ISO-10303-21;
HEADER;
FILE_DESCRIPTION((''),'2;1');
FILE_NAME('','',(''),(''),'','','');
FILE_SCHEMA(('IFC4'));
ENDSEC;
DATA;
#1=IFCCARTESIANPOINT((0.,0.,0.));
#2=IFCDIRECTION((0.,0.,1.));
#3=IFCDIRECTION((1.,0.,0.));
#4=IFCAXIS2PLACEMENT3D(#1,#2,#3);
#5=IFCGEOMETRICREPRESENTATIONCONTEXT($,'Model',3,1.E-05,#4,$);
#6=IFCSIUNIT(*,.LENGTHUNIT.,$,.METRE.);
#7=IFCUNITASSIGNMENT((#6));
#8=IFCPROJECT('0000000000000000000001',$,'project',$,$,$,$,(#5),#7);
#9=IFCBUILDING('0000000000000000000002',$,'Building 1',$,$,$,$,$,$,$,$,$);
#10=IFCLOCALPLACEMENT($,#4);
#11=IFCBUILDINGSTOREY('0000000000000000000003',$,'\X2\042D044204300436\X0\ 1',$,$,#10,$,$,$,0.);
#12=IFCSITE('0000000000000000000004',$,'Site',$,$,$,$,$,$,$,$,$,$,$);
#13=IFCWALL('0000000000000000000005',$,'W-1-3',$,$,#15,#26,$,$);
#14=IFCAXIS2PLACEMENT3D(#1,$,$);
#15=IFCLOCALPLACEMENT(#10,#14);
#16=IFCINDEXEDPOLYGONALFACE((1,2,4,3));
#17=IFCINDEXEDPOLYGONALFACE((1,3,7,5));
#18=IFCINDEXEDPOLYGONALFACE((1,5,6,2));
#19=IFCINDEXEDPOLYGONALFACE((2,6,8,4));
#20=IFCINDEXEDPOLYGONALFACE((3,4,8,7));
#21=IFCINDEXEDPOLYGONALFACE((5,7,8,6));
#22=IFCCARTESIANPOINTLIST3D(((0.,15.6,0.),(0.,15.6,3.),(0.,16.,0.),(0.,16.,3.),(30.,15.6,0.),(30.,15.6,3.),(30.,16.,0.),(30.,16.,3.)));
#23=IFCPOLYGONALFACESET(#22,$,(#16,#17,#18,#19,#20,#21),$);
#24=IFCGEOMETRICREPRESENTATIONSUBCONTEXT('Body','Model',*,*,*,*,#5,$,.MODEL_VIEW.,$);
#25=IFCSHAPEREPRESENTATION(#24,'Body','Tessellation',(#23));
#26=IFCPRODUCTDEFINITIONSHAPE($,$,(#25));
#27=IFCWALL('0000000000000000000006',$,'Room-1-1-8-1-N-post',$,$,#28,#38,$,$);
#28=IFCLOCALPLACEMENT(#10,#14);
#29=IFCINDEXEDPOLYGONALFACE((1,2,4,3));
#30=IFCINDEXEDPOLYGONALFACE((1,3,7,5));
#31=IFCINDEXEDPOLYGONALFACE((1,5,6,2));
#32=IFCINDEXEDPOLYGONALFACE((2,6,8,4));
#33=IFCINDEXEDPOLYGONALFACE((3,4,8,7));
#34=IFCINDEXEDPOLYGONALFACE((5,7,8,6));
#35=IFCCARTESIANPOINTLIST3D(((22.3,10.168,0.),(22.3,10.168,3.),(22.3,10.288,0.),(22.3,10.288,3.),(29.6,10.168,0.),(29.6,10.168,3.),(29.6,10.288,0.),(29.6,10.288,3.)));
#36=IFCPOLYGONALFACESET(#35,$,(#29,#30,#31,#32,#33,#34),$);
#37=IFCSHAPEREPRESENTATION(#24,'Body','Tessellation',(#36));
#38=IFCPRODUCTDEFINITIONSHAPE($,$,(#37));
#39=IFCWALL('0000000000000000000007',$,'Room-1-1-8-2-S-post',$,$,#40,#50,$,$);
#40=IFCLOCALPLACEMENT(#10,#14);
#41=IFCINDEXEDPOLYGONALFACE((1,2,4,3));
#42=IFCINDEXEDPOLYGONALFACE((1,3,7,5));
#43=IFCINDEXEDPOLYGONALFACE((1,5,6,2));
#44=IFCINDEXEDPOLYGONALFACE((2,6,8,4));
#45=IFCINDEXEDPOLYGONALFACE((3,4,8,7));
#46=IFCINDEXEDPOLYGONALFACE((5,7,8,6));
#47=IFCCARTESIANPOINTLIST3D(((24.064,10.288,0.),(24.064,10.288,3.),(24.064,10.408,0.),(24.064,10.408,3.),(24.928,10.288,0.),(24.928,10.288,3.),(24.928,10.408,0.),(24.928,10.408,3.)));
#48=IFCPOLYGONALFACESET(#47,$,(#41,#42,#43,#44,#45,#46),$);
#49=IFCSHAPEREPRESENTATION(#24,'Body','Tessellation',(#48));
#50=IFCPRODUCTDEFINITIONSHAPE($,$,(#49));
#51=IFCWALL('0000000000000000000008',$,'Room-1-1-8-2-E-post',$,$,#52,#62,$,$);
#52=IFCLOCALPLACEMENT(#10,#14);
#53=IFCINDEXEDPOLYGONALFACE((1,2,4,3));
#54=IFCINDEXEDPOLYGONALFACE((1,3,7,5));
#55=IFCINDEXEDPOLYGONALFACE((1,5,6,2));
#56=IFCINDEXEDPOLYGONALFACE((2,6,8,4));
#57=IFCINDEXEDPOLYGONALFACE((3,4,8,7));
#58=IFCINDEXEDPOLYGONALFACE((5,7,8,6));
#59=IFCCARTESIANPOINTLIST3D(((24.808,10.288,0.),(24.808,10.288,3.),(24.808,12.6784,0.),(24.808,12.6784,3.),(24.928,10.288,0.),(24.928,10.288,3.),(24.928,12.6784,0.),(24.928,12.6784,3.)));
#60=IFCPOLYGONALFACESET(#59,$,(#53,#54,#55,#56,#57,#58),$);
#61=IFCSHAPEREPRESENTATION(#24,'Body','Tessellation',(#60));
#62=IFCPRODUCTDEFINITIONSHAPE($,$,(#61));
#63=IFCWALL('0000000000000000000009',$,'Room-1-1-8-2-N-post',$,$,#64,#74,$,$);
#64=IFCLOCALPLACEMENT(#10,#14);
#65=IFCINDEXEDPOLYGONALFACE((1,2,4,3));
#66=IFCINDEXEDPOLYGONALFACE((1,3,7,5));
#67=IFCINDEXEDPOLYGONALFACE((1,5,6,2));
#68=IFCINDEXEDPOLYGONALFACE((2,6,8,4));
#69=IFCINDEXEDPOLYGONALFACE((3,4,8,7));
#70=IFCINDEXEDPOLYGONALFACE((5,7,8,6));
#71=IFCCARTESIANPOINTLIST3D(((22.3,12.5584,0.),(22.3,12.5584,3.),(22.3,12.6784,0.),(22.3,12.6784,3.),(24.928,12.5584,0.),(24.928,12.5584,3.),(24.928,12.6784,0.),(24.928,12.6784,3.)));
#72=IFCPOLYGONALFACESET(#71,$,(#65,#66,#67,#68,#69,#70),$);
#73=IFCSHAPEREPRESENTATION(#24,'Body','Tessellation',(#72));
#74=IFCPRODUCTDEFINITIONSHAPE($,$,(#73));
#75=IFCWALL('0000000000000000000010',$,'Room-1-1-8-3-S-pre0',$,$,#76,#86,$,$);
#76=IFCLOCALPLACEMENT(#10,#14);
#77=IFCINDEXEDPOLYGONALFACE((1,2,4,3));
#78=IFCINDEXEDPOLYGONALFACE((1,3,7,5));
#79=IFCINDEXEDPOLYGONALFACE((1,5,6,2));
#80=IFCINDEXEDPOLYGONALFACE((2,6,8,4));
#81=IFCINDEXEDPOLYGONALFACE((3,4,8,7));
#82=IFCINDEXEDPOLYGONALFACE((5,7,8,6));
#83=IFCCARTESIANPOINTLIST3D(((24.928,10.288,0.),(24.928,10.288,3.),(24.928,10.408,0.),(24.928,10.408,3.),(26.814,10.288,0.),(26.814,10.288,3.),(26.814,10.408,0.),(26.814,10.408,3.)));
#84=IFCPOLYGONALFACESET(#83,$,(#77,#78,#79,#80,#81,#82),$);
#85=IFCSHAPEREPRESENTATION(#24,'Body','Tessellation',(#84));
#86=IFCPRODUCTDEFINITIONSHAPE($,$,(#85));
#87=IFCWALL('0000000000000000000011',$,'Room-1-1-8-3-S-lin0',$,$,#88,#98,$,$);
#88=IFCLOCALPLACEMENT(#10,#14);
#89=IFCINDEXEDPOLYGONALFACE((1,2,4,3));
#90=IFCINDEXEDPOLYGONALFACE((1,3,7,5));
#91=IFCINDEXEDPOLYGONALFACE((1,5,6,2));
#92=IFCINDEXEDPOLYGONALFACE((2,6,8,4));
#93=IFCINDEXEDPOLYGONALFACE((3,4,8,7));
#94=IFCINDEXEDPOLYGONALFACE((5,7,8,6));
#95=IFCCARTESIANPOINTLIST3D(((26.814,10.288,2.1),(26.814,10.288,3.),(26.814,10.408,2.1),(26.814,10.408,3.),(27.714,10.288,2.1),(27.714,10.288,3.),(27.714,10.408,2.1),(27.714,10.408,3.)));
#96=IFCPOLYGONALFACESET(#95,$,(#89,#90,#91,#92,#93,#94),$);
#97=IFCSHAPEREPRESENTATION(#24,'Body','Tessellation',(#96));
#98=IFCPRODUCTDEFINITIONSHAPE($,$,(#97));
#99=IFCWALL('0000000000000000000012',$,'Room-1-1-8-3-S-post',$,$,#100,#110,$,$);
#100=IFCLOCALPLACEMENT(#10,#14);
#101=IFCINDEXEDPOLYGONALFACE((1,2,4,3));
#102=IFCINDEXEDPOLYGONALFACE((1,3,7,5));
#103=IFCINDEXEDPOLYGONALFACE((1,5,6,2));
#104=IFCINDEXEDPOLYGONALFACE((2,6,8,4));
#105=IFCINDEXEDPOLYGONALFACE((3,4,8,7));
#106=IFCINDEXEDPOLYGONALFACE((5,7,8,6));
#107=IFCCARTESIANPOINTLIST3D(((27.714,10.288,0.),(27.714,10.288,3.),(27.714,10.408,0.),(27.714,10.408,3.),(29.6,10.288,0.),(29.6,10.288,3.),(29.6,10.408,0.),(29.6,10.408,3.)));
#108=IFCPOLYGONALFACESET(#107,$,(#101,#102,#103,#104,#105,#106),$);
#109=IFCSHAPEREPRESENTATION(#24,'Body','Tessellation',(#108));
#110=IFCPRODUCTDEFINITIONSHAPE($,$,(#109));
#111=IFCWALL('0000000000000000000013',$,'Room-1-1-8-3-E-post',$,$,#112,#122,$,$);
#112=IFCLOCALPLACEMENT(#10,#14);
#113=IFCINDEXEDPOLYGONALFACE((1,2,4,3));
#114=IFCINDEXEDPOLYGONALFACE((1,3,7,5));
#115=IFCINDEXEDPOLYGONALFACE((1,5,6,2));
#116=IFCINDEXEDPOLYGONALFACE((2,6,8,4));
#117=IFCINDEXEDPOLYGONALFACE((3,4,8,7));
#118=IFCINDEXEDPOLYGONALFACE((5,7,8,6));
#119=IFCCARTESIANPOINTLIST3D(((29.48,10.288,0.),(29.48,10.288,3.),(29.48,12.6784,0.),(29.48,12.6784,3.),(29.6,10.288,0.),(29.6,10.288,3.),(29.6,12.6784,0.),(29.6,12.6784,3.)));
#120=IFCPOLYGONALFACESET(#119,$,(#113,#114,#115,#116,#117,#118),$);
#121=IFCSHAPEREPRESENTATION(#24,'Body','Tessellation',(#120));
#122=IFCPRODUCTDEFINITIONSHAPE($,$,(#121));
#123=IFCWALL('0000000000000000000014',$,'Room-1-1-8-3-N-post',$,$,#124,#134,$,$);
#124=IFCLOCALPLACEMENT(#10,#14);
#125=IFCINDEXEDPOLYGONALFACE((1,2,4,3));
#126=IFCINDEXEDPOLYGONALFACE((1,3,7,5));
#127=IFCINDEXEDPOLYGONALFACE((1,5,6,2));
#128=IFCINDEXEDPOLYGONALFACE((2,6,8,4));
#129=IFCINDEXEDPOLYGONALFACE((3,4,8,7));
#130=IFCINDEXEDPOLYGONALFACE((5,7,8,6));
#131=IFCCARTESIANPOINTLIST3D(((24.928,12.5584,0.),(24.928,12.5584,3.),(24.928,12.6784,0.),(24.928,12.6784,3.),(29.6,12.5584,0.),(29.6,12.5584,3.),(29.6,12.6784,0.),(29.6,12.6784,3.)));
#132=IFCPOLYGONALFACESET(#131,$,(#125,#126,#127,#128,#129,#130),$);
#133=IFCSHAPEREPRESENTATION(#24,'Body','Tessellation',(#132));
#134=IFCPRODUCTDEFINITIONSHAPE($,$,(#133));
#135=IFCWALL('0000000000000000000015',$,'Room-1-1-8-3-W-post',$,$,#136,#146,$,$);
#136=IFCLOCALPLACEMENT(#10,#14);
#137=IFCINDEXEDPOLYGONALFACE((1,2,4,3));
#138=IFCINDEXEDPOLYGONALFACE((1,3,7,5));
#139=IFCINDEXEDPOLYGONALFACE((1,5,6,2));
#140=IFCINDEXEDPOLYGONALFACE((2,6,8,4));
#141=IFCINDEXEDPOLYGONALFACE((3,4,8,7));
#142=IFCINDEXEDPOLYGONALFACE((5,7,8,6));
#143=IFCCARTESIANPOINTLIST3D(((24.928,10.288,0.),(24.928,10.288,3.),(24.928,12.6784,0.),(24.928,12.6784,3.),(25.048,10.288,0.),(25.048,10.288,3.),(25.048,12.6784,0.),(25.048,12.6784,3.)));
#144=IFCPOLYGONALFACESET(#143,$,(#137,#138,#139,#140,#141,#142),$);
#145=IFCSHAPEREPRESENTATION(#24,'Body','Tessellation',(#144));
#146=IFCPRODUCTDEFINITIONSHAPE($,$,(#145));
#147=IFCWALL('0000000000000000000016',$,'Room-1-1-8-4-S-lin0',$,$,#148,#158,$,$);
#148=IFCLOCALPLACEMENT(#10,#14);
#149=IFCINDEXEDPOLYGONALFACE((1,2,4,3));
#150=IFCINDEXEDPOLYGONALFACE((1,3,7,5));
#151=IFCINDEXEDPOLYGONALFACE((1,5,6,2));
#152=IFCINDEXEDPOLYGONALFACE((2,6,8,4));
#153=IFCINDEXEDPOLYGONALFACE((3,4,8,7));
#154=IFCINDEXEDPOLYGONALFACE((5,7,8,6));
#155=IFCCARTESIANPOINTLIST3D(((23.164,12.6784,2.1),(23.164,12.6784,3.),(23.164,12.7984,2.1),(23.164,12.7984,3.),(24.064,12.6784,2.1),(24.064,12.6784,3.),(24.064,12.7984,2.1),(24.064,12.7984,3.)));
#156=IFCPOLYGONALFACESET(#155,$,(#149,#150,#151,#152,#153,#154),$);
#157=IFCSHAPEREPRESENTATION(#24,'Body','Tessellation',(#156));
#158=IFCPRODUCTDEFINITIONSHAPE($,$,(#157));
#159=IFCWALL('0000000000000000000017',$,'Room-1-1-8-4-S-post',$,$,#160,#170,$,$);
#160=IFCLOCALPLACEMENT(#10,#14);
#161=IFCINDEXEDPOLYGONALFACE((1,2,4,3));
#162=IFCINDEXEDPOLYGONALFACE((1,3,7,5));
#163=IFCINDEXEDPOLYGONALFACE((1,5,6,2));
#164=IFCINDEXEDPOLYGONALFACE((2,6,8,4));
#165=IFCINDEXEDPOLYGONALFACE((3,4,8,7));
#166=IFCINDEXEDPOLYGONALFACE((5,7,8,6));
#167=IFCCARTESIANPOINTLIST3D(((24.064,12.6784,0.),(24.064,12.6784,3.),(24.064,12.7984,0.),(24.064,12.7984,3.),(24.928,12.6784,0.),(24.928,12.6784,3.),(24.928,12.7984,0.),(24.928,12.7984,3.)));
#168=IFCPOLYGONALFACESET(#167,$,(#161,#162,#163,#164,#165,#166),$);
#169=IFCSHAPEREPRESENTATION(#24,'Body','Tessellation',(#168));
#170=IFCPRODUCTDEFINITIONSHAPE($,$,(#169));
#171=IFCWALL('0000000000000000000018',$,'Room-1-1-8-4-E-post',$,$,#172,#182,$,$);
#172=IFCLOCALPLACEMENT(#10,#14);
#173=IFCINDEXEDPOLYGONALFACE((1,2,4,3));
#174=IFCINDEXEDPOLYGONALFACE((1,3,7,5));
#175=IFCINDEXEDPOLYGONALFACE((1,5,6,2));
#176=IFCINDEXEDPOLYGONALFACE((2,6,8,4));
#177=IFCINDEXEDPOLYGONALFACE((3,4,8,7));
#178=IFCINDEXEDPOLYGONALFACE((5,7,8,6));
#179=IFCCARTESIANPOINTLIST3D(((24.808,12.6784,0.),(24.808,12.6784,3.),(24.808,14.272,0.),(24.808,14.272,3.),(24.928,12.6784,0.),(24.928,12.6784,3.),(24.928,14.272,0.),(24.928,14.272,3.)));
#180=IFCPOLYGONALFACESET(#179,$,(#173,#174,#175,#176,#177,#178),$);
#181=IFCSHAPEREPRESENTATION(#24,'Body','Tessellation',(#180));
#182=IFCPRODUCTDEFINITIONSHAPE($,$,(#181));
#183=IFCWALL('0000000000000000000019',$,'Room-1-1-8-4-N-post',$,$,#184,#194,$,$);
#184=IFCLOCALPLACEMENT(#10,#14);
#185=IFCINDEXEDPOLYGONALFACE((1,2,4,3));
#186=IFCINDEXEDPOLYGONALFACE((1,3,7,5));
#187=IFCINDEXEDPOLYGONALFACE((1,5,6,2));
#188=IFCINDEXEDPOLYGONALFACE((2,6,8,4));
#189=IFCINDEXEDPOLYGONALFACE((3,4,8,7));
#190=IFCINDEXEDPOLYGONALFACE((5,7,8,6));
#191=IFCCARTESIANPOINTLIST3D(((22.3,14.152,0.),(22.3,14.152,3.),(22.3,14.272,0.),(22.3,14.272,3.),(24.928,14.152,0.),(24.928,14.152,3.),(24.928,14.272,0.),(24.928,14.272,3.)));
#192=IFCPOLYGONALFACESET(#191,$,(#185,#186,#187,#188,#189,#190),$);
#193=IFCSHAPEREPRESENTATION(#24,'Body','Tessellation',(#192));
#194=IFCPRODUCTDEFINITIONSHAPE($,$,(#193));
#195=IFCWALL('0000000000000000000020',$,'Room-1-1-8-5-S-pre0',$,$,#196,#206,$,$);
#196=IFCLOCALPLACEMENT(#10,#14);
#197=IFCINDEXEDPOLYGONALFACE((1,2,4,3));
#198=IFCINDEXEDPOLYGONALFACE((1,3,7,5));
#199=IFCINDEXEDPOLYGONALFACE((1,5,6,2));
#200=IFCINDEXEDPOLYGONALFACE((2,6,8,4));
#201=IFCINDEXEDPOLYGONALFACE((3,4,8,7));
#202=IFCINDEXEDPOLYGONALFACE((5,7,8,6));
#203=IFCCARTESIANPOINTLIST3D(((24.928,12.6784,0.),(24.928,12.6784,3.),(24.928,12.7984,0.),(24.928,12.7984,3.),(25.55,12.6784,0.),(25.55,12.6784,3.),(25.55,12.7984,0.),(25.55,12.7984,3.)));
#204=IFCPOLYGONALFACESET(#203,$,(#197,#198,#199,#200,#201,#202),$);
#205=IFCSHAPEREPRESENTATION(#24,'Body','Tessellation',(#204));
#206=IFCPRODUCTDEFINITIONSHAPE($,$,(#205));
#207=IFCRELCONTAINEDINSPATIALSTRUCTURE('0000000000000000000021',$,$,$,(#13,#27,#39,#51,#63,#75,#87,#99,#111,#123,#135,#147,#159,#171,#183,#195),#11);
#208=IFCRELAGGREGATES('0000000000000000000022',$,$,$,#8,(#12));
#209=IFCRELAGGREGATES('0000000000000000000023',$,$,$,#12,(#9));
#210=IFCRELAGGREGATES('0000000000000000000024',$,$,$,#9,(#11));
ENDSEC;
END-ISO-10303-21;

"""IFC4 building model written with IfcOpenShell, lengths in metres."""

from ifc_helpers import new_model, si_unit, frame, origin_with_axes, place, context, subcontext, project, spatial, indexed_curve, outline, extrude, element, save


model = new_model("IFC4")

# Units and contexts
model_context = context("Model", 3, precision=1e-05, world=origin_with_axes())
body_context = subcontext(model_context, "Body", "Model", "MODEL_VIEW")
ifc_project = project(units=[si_unit("LENGTHUNIT", "METRE")], contexts=[model_context])

# Site, building, storey
site = spatial("IfcSite", under=ifc_project, Name="Site")
building = spatial("IfcBuilding", under=site, Name="Building 1")
storey_placement = place(None, origin_with_axes())
storey = spatial("IfcBuildingStorey", under=building, at=storey_placement, Name="Этаж 1", Elevation=0.0)

# Walls
wall_1_placement = place(storey_placement, frame((30.0, 16.0, 0.0), z_axis=(0.0, 0.0, 1.0), x_axis=(-1.0, 0.0, 0.0)))
element("IfcWall", 1, at=wall_1_placement, inside=storey, Name="W-1-3", context=body_context, shape_type="SweptSolid", body=[
    extrude(outline(indexed_curve([(0.0, 0.0), (0.0, 0.4), (30.0, 0.4), (30.0, 0.0), (0.0, 0.0)], self_intersect=False)), origin_with_axes(), (0.0, 0.0, 1.0), 3.0),
])
wall_2_placement = place(storey_placement, frame((29.6, 10.288, 0.0), z_axis=(0.0, 0.0, 1.0), x_axis=(-1.0, 0.0, 0.0)))
element("IfcWall", 2, at=wall_2_placement, inside=storey, Name="Room-1-1-8-1-N-post", context=body_context, shape_type="SweptSolid", body=[
    extrude(outline(indexed_curve([(0.0, 0.0), (0.0, 0.12), (7.3, 0.12), (7.3, 0.0), (0.0, 0.0)], self_intersect=False)), origin_with_axes(), (0.0, 0.0, 1.0), 3.0),
])
wall_3_placement = place(storey_placement, frame((24.064, 10.288, 0.0), z_axis=(0.0, 0.0, 1.0), x_axis=(1.0, 0.0, 0.0)))
element("IfcWall", 3, at=wall_3_placement, inside=storey, Name="Room-1-1-8-2-S-post", context=body_context, shape_type="SweptSolid", body=[
    extrude(outline(indexed_curve([(0.0, 0.0), (0.0, 0.12), (0.864, 0.12), (0.864, 0.0), (0.0, 0.0)], self_intersect=False)), origin_with_axes(), (0.0, 0.0, 1.0), 3.0),
])
wall_4_placement = place(storey_placement, frame((24.928, 10.288, 0.0), z_axis=(0.0, 0.0, 1.0), x_axis=(0.0, 1.0, 0.0)))
element("IfcWall", 4, at=wall_4_placement, inside=storey, Name="Room-1-1-8-2-E-post", context=body_context, shape_type="SweptSolid", body=[
    extrude(outline(indexed_curve([(0.0, 0.0), (0.0, 0.12), (2.3904, 0.12), (2.3904, 0.0), (0.0, 0.0)], self_intersect=False)), origin_with_axes(), (0.0, 0.0, 1.0), 3.0),
])
wall_5_placement = place(storey_placement, frame((24.928, 12.6784, 0.0), z_axis=(0.0, 0.0, 1.0), x_axis=(-1.0, 0.0, 0.0)))
element("IfcWall", 5, at=wall_5_placement, inside=storey, Name="Room-1-1-8-2-N-post", context=body_context, shape_type="SweptSolid", body=[
    extrude(outline(indexed_curve([(0.0, 0.0), (0.0, 0.12), (2.628, 0.12), (2.628, 0.0), (0.0, 0.0)], self_intersect=False)), origin_with_axes(), (0.0, 0.0, 1.0), 3.0),
])
wall_6_placement = place(storey_placement, frame((24.928, 10.288, 0.0), z_axis=(0.0, 0.0, 1.0), x_axis=(1.0, 0.0, 0.0)))
element("IfcWall", 6, at=wall_6_placement, inside=storey, Name="Room-1-1-8-3-S-pre0", context=body_context, shape_type="SweptSolid", body=[
    extrude(outline(indexed_curve([(0.0, 0.0), (0.0, 0.12), (1.886, 0.12), (1.886, 0.0), (0.0, 0.0)], self_intersect=False)), origin_with_axes(), (0.0, 0.0, 1.0), 3.0),
])
wall_7_placement = place(storey_placement, frame((26.814, 10.288, 2.1), z_axis=(0.0, 0.0, 1.0), x_axis=(1.0, 0.0, 0.0)))
element("IfcWall", 7, at=wall_7_placement, inside=storey, Name="Room-1-1-8-3-S-lin0", context=body_context, shape_type="SweptSolid", body=[
    extrude(outline(indexed_curve([(0.0, 0.0), (0.0, 0.12), (0.9, 0.12), (0.9, 0.0), (0.0, 0.0)], self_intersect=False)), origin_with_axes(), (0.0, 0.0, 1.0), 0.9),
])
wall_8_placement = place(storey_placement, frame((27.714, 10.288, 0.0), z_axis=(0.0, 0.0, 1.0), x_axis=(1.0, 0.0, 0.0)))
element("IfcWall", 8, at=wall_8_placement, inside=storey, Name="Room-1-1-8-3-S-post", context=body_context, shape_type="SweptSolid", body=[
    extrude(outline(indexed_curve([(0.0, 0.0), (0.0, 0.12), (1.886, 0.12), (1.886, 0.0), (0.0, 0.0)], self_intersect=False)), origin_with_axes(), (0.0, 0.0, 1.0), 3.0),
])
wall_9_placement = place(storey_placement, frame((29.6, 10.288, 0.0), z_axis=(0.0, 0.0, 1.0), x_axis=(0.0, 1.0, 0.0)))
element("IfcWall", 9, at=wall_9_placement, inside=storey, Name="Room-1-1-8-3-E-post", context=body_context, shape_type="SweptSolid", body=[
    extrude(outline(indexed_curve([(0.0, 0.0), (0.0, 0.12), (2.3904, 0.12), (2.3904, 0.0), (0.0, 0.0)], self_intersect=False)), origin_with_axes(), (0.0, 0.0, 1.0), 3.0),
])
wall_10_placement = place(storey_placement, frame((29.6, 12.6784, 0.0), z_axis=(0.0, 0.0, 1.0), x_axis=(-1.0, 0.0, 0.0)))
element("IfcWall", 10, at=wall_10_placement, inside=storey, Name="Room-1-1-8-3-N-post", context=body_context, shape_type="SweptSolid", body=[
    extrude(outline(indexed_curve([(0.0, 0.0), (0.0, 0.12), (4.672, 0.12), (4.672, 0.0), (0.0, 0.0)], self_intersect=False)), origin_with_axes(), (0.0, 0.0, 1.0), 3.0),
])
wall_11_placement = place(storey_placement, frame((24.928, 12.6784, 0.0), z_axis=(0.0, 0.0, 1.0), x_axis=(0.0, -1.0, 0.0)))
element("IfcWall", 11, at=wall_11_placement, inside=storey, Name="Room-1-1-8-3-W-post", context=body_context, shape_type="SweptSolid", body=[
    extrude(outline(indexed_curve([(0.0, 0.0), (0.0, 0.12), (2.3904, 0.12), (2.3904, 0.0), (0.0, 0.0)], self_intersect=False)), origin_with_axes(), (0.0, 0.0, 1.0), 3.0),
])
wall_12_placement = place(storey_placement, frame((23.164, 12.6784, 2.1), z_axis=(0.0, 0.0, 1.0), x_axis=(1.0, 0.0, 0.0)))
element("IfcWall", 12, at=wall_12_placement, inside=storey, Name="Room-1-1-8-4-S-lin0", context=body_context, shape_type="SweptSolid", body=[
    extrude(outline(indexed_curve([(0.0, 0.0), (0.0, 0.12), (0.9, 0.12), (0.9, 0.0), (0.0, 0.0)], self_intersect=False)), origin_with_axes(), (0.0, 0.0, 1.0), 0.9),
])
wall_13_placement = place(storey_placement, frame((24.064, 12.6784, 0.0), z_axis=(0.0, 0.0, 1.0), x_axis=(1.0, 0.0, 0.0)))
element("IfcWall", 13, at=wall_13_placement, inside=storey, Name="Room-1-1-8-4-S-post", context=body_context, shape_type="SweptSolid", body=[
    extrude(outline(indexed_curve([(0.0, 0.0), (0.0, 0.12), (0.864, 0.12), (0.864, 0.0), (0.0, 0.0)], self_intersect=False)), origin_with_axes(), (0.0, 0.0, 1.0), 3.0),
])
wall_14_placement = place(storey_placement, frame((24.928, 12.6784, 0.0), z_axis=(0.0, 0.0, 1.0), x_axis=(0.0, 1.0, 0.0)))
element("IfcWall", 14, at=wall_14_placement, inside=storey, Name="Room-1-1-8-4-E-post", context=body_context, shape_type="SweptSolid", body=[
    extrude(outline(indexed_curve([(0.0, 0.0), (0.0, 0.12), (1.5936, 0.12), (1.5936, 0.0), (0.0, 0.0)], self_intersect=False)), origin_with_axes(), (0.0, 0.0, 1.0), 3.0),
])
wall_15_placement = place(storey_placement, frame((24.928, 14.272, 0.0), z_axis=(0.0, 0.0, 1.0), x_axis=(-1.0, 0.0, 0.0)))
element("IfcWall", 15, at=wall_15_placement, inside=storey, Name="Room-1-1-8-4-N-post", context=body_context, shape_type="SweptSolid", body=[
    extrude(outline(indexed_curve([(0.0, 0.0), (0.0, 0.12), (2.628, 0.12), (2.628, 0.0), (0.0, 0.0)], self_intersect=False)), origin_with_axes(), (0.0, 0.0, 1.0), 3.0),
])
wall_16_placement = place(storey_placement, frame((24.928, 12.6784, 0.0), z_axis=(0.0, 0.0, 1.0), x_axis=(1.0, 0.0, 0.0)))
element("IfcWall", 16, at=wall_16_placement, inside=storey, Name="Room-1-1-8-5-S-pre0", context=body_context, shape_type="SweptSolid", body=[
    extrude(outline(indexed_curve([(0.0, 0.0), (0.0, 0.12), (0.622, 0.12), (0.622, 0.0), (0.0, 0.0)], self_intersect=False)), origin_with_axes(), (0.0, 0.0, 1.0), 3.0),
])

save(model, "model.ifc")
